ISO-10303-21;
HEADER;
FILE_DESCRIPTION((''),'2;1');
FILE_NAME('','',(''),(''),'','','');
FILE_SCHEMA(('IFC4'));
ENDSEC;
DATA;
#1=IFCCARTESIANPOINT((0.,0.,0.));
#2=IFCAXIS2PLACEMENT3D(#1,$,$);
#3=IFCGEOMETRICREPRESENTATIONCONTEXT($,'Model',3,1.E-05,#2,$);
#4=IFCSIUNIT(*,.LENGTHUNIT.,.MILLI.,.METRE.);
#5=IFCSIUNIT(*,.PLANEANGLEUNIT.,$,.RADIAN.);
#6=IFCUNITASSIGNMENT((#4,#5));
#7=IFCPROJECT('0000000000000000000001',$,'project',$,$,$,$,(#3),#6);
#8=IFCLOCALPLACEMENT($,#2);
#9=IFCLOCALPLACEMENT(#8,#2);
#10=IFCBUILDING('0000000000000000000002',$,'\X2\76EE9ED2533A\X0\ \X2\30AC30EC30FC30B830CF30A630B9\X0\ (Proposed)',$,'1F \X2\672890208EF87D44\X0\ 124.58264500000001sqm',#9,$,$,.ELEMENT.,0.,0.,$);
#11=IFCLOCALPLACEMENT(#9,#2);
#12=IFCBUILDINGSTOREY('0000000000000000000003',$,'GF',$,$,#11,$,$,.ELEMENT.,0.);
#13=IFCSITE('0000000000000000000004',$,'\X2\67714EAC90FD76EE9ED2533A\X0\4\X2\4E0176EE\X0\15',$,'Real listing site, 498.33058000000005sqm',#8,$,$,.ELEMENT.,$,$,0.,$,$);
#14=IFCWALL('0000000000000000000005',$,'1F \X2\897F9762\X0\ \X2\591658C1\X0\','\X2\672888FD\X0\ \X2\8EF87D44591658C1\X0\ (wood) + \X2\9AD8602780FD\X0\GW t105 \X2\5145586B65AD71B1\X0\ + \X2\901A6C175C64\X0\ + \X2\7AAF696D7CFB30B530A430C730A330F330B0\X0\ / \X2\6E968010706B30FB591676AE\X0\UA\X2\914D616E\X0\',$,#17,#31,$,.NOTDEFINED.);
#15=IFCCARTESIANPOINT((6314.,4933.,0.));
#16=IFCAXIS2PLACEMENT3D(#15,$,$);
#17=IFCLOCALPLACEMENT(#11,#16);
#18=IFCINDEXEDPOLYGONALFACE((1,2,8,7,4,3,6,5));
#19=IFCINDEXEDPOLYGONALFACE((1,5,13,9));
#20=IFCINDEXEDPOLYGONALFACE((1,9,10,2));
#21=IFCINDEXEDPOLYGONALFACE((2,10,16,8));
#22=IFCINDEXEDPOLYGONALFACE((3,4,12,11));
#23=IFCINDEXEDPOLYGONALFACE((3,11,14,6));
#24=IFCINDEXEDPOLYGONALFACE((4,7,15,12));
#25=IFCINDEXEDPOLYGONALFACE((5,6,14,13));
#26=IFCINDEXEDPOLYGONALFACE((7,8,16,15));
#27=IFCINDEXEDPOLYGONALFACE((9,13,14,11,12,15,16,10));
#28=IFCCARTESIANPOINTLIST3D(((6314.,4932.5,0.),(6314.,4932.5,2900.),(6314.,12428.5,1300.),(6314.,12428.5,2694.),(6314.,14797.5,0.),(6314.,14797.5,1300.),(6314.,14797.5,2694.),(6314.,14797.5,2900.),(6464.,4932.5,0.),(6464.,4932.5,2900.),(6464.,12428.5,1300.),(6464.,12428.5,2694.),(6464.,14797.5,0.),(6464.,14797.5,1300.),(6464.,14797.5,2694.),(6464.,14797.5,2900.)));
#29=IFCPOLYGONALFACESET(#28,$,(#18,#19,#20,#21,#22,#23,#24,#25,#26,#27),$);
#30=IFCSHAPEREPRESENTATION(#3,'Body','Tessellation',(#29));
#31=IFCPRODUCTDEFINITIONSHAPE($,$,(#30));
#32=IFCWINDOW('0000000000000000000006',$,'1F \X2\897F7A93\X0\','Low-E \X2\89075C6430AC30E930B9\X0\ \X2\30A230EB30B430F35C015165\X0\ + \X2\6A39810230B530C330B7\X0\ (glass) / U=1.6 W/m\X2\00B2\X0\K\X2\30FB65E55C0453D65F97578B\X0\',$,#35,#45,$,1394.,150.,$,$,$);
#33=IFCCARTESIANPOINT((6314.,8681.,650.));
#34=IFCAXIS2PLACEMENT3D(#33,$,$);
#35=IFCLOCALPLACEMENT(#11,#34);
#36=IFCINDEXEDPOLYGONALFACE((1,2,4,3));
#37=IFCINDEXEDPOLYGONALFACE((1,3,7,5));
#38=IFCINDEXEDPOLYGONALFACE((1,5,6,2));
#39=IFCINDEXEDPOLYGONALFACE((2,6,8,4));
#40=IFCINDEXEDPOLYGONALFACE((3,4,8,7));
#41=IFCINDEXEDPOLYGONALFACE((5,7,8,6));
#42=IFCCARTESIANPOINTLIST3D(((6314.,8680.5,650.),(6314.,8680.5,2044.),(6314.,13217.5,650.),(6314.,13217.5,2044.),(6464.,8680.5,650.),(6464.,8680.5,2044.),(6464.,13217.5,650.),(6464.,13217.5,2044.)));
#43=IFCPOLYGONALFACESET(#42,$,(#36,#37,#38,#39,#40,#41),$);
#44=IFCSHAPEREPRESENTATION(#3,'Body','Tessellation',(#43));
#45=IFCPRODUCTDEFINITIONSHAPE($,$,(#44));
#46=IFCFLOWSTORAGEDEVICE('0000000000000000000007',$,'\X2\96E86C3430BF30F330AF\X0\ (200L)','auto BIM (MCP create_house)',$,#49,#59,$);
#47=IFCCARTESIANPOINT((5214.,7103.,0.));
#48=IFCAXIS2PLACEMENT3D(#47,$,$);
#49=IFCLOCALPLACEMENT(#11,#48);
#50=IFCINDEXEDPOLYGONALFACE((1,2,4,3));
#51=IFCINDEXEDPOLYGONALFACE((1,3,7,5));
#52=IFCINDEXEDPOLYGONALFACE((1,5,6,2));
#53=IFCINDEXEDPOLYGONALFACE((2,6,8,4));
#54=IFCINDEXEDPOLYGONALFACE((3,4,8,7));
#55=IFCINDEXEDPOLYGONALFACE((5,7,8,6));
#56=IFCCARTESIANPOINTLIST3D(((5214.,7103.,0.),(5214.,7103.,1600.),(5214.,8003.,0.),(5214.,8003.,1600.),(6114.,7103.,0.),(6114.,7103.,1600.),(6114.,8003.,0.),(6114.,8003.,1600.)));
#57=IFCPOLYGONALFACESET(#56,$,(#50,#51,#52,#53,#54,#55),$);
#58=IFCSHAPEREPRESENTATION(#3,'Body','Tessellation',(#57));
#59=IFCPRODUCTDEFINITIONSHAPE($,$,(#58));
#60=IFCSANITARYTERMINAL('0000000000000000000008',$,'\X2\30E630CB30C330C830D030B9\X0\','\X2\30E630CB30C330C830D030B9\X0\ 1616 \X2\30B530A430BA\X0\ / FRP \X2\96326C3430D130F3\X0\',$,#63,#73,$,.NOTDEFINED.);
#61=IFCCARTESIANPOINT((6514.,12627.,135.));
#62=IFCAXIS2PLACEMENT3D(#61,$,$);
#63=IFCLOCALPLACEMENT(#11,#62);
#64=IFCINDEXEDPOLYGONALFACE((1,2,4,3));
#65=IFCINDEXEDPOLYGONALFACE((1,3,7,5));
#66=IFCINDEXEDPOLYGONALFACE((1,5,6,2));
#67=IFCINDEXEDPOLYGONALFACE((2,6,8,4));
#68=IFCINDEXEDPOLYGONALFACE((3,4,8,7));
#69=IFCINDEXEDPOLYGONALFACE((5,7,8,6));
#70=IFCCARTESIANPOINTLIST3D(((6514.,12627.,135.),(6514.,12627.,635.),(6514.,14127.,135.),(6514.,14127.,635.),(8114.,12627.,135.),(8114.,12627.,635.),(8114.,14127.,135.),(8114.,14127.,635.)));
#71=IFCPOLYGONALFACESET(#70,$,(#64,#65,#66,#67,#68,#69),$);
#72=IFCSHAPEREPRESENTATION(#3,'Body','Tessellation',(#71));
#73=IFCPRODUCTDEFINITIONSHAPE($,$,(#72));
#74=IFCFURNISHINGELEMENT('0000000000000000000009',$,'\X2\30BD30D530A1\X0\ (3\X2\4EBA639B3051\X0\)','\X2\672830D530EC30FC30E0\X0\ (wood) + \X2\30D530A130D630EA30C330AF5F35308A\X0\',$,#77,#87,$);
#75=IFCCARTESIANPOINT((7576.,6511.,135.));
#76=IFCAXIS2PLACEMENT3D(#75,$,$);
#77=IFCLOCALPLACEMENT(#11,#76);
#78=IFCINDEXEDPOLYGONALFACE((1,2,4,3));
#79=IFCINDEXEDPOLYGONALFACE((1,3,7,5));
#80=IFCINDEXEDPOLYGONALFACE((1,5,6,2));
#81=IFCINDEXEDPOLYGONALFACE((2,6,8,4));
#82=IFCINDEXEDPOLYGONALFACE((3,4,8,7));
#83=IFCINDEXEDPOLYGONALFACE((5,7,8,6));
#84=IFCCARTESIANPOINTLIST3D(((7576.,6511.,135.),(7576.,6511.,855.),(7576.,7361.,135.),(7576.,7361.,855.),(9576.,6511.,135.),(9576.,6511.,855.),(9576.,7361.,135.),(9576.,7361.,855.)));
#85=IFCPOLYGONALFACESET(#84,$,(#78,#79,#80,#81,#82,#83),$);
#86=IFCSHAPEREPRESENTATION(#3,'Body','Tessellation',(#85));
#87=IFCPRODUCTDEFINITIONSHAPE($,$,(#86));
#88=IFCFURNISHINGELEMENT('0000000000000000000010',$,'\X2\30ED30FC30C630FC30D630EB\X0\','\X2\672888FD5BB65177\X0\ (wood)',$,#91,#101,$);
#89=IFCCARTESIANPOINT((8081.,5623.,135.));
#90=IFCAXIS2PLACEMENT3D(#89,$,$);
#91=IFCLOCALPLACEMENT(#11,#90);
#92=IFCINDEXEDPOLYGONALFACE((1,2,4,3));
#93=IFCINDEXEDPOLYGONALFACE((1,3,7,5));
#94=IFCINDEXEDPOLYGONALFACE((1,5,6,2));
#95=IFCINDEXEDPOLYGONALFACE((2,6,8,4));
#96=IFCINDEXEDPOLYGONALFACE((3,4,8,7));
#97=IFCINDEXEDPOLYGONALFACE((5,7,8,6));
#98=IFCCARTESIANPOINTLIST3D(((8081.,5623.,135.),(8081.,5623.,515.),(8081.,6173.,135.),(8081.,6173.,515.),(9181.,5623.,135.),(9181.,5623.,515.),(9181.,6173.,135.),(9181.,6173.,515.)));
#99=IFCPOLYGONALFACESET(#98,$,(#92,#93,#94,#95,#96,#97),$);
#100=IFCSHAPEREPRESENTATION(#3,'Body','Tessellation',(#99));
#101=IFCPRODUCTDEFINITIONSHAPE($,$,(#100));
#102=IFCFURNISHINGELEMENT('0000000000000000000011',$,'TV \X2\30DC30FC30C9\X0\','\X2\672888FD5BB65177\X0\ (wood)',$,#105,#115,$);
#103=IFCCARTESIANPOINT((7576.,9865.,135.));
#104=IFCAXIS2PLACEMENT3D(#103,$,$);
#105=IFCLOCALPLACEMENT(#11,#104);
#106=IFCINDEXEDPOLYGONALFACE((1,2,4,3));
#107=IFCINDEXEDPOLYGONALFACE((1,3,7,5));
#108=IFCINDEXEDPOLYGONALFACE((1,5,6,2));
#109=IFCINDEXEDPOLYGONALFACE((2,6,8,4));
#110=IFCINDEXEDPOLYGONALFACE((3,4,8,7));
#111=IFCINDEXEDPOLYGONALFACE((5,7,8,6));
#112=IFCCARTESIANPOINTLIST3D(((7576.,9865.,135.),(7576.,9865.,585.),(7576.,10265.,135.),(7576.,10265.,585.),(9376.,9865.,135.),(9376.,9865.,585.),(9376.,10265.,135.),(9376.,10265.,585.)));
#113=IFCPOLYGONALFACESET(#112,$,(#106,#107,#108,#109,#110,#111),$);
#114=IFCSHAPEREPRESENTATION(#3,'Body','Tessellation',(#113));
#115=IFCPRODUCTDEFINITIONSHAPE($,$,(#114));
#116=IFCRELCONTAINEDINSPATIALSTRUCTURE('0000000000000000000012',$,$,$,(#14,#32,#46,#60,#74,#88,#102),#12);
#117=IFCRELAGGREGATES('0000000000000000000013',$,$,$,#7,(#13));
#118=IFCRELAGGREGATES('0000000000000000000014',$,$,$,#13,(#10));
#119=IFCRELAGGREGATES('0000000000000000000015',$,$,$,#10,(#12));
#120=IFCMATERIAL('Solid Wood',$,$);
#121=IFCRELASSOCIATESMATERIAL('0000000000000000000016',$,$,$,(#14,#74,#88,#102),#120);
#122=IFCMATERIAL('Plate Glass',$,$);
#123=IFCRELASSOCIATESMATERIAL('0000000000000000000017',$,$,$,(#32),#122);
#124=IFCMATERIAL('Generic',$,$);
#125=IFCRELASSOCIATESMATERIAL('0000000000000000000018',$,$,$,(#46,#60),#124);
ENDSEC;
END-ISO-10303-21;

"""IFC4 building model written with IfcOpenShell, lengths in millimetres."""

from ifc_helpers import new_model, si_unit, frame, frame_2d, origin, place, context, project, spatial, rectangle, extrude, material, element, fill, save


model = new_model("IFC4")

# Units and contexts
model_context = context("Model", 3, precision=1e-05, world=origin())
ifc_project = project(units=[si_unit("LENGTHUNIT", "METRE", prefix="MILLI"), si_unit("PLANEANGLEUNIT", "RADIAN")], contexts=[model_context])

# Site, building, storey
site_placement = place(None, origin())
site = spatial("IfcSite", under=ifc_project, at=site_placement, Name="東京都目黒区4丁目15", ObjectType="Real listing site, 498.33058000000005sqm", CompositionType="ELEMENT", RefElevation=0.0)
building_placement = place(site_placement, origin())
building = spatial("IfcBuilding", under=site, at=building_placement, Name="目黒区 ガレージハウス (Proposed)", ObjectType="1F 木造軸組 124.58264500000001sqm", CompositionType="ELEMENT", ElevationOfRefHeight=0.0, ElevationOfTerrain=0.0)
storey_placement = place(building_placement, origin())
storey = spatial("IfcBuildingStorey", under=building, at=storey_placement, Name="GF", CompositionType="ELEMENT", Elevation=0.0)

# Shared definitions
ifc_material_1 = material(Name="Solid Wood")

# Shared definitions
ifc_material_2 = material(Name="Plate Glass")

# Wall, opening, window
wall_1_placement = place(storey_placement, frame((6314.0, 4933.0, 0.0)))
wall_1 = element("IfcWall", 1, at=wall_1_placement, inside=storey, material=ifc_material_1, Name="1F 西面 外壁", Description="木製 軸組外壁 (wood) + 高性能GW t105 充填断熱 + 通気層 + 窯業系サイディング / 準耐火・外皮UA配慮", PredefinedType="NOTDEFINED", context=model_context, shape_type="SweptSolid", body=[
    extrude(rectangle(XDim=150.0, YDim=9865.0, at=frame_2d((75.0, 4932.0))), frame((6314.0, 4933.0, 0.0)), (0.0, 0.0, 1.0), 2900.0),
])
opening_1_placement = place(storey_placement, frame((6314.0, 8681.0, 650.0)))
opening_1 = element("IfcOpeningElement", 2, at=opening_1_placement, cuts=wall_1, PredefinedType="NOTDEFINED", context=model_context, shape_type="SweptSolid", body=[
    extrude(rectangle(XDim=150.0, YDim=4537.0, at=frame_2d((75.0, 2268.0))), frame((6314.0, 8681.0, 650.0)), (0.0, 0.0, 1.0), 1394.0),
])
window_1_placement = place(storey_placement, frame((6314.0, 8681.0, 650.0)))
window_1 = element("IfcWindow", 3, at=window_1_placement, inside=storey, material=ifc_material_2, Name="1F 西窓", Description="Low-E 複層ガラス アルゴン封入 + 樹脂サッシ (glass) / U=1.6 W/m²K・日射取得型", OverallHeight=1394.0, OverallWidth=150.0, context=model_context, shape_type="SweptSolid", body=[
    extrude(rectangle(XDim=150.0, YDim=4537.0, at=frame_2d((75.0, 2268.0))), frame((6314.0, 8681.0, 650.0)), (0.0, 0.0, 1.0), 1394.0),
])
fill(opening_1, window_1)

# Shared definitions
ifc_material_3 = material(Name="Generic")

# Flow storage device
flow_storage_device_placement = place(storey_placement, frame((5214.0, 7103.0, 0.0)))
element("IfcFlowStorageDevice", 4, at=flow_storage_device_placement, inside=storey, material=ifc_material_3, Name="雨水タンク (200L)", Description="auto BIM (MCP create_house)", context=model_context, shape_type="SweptSolid", body=[
    extrude(rectangle(XDim=900.0, YDim=900.0, at=frame_2d((450.0, 450.0))), frame((5214.0, 7103.0, 0.0)), (0.0, 0.0, 1.0), 1600.0),
])

# Sanitary terminal
sanitary_terminal_placement = place(storey_placement, frame((6514.0, 12627.0, 135.0)))
element("IfcSanitaryTerminal", 5, at=sanitary_terminal_placement, inside=storey, material=ifc_material_3, Name="ユニットバス", Description="ユニットバス 1616 サイズ / FRP 防水パン", PredefinedType="NOTDEFINED", context=model_context, shape_type="SweptSolid", body=[
    extrude(rectangle(XDim=1600.0, YDim=1500.0, at=frame_2d((800.0, 750.0))), frame((6514.0, 12627.0, 135.0)), (0.0, 0.0, 1.0), 500.0),
])

# Furnishing elements
furnishing_1_placement = place(storey_placement, frame((7576.0, 6511.0, 135.0)))
element("IfcFurnishingElement", 6, at=furnishing_1_placement, inside=storey, material=ifc_material_1, Name="ソファ (3人掛け)", Description="木フレーム (wood) + ファブリック張り", context=model_context, shape_type="SweptSolid", body=[
    extrude(rectangle(XDim=2000.0, YDim=850.0, at=frame_2d((1000.0, 425.0))), frame((7576.0, 6511.0, 135.0)), (0.0, 0.0, 1.0), 720.0),
])
furnishing_2_placement = place(storey_placement, frame((8081.0, 5623.0, 135.0)))
element("IfcFurnishingElement", 7, at=furnishing_2_placement, inside=storey, material=ifc_material_1, Name="ローテーブル", Description="木製家具 (wood)", context=model_context, shape_type="SweptSolid", body=[
    extrude(rectangle(XDim=1100.0, YDim=550.0, at=frame_2d((550.0, 275.0))), frame((8081.0, 5623.0, 135.0)), (0.0, 0.0, 1.0), 380.0),
])
furnishing_3_placement = place(storey_placement, frame((7576.0, 9865.0, 135.0)))
element("IfcFurnishingElement", 8, at=furnishing_3_placement, inside=storey, material=ifc_material_1, Name="TV ボード", Description="木製家具 (wood)", context=model_context, shape_type="SweptSolid", body=[
    extrude(rectangle(XDim=1800.0, YDim=400.0, at=frame_2d((900.0, 200.0))), frame((7576.0, 9865.0, 135.0)), (0.0, 0.0, 1.0), 450.0),
])

save(model, "model.ifc")
